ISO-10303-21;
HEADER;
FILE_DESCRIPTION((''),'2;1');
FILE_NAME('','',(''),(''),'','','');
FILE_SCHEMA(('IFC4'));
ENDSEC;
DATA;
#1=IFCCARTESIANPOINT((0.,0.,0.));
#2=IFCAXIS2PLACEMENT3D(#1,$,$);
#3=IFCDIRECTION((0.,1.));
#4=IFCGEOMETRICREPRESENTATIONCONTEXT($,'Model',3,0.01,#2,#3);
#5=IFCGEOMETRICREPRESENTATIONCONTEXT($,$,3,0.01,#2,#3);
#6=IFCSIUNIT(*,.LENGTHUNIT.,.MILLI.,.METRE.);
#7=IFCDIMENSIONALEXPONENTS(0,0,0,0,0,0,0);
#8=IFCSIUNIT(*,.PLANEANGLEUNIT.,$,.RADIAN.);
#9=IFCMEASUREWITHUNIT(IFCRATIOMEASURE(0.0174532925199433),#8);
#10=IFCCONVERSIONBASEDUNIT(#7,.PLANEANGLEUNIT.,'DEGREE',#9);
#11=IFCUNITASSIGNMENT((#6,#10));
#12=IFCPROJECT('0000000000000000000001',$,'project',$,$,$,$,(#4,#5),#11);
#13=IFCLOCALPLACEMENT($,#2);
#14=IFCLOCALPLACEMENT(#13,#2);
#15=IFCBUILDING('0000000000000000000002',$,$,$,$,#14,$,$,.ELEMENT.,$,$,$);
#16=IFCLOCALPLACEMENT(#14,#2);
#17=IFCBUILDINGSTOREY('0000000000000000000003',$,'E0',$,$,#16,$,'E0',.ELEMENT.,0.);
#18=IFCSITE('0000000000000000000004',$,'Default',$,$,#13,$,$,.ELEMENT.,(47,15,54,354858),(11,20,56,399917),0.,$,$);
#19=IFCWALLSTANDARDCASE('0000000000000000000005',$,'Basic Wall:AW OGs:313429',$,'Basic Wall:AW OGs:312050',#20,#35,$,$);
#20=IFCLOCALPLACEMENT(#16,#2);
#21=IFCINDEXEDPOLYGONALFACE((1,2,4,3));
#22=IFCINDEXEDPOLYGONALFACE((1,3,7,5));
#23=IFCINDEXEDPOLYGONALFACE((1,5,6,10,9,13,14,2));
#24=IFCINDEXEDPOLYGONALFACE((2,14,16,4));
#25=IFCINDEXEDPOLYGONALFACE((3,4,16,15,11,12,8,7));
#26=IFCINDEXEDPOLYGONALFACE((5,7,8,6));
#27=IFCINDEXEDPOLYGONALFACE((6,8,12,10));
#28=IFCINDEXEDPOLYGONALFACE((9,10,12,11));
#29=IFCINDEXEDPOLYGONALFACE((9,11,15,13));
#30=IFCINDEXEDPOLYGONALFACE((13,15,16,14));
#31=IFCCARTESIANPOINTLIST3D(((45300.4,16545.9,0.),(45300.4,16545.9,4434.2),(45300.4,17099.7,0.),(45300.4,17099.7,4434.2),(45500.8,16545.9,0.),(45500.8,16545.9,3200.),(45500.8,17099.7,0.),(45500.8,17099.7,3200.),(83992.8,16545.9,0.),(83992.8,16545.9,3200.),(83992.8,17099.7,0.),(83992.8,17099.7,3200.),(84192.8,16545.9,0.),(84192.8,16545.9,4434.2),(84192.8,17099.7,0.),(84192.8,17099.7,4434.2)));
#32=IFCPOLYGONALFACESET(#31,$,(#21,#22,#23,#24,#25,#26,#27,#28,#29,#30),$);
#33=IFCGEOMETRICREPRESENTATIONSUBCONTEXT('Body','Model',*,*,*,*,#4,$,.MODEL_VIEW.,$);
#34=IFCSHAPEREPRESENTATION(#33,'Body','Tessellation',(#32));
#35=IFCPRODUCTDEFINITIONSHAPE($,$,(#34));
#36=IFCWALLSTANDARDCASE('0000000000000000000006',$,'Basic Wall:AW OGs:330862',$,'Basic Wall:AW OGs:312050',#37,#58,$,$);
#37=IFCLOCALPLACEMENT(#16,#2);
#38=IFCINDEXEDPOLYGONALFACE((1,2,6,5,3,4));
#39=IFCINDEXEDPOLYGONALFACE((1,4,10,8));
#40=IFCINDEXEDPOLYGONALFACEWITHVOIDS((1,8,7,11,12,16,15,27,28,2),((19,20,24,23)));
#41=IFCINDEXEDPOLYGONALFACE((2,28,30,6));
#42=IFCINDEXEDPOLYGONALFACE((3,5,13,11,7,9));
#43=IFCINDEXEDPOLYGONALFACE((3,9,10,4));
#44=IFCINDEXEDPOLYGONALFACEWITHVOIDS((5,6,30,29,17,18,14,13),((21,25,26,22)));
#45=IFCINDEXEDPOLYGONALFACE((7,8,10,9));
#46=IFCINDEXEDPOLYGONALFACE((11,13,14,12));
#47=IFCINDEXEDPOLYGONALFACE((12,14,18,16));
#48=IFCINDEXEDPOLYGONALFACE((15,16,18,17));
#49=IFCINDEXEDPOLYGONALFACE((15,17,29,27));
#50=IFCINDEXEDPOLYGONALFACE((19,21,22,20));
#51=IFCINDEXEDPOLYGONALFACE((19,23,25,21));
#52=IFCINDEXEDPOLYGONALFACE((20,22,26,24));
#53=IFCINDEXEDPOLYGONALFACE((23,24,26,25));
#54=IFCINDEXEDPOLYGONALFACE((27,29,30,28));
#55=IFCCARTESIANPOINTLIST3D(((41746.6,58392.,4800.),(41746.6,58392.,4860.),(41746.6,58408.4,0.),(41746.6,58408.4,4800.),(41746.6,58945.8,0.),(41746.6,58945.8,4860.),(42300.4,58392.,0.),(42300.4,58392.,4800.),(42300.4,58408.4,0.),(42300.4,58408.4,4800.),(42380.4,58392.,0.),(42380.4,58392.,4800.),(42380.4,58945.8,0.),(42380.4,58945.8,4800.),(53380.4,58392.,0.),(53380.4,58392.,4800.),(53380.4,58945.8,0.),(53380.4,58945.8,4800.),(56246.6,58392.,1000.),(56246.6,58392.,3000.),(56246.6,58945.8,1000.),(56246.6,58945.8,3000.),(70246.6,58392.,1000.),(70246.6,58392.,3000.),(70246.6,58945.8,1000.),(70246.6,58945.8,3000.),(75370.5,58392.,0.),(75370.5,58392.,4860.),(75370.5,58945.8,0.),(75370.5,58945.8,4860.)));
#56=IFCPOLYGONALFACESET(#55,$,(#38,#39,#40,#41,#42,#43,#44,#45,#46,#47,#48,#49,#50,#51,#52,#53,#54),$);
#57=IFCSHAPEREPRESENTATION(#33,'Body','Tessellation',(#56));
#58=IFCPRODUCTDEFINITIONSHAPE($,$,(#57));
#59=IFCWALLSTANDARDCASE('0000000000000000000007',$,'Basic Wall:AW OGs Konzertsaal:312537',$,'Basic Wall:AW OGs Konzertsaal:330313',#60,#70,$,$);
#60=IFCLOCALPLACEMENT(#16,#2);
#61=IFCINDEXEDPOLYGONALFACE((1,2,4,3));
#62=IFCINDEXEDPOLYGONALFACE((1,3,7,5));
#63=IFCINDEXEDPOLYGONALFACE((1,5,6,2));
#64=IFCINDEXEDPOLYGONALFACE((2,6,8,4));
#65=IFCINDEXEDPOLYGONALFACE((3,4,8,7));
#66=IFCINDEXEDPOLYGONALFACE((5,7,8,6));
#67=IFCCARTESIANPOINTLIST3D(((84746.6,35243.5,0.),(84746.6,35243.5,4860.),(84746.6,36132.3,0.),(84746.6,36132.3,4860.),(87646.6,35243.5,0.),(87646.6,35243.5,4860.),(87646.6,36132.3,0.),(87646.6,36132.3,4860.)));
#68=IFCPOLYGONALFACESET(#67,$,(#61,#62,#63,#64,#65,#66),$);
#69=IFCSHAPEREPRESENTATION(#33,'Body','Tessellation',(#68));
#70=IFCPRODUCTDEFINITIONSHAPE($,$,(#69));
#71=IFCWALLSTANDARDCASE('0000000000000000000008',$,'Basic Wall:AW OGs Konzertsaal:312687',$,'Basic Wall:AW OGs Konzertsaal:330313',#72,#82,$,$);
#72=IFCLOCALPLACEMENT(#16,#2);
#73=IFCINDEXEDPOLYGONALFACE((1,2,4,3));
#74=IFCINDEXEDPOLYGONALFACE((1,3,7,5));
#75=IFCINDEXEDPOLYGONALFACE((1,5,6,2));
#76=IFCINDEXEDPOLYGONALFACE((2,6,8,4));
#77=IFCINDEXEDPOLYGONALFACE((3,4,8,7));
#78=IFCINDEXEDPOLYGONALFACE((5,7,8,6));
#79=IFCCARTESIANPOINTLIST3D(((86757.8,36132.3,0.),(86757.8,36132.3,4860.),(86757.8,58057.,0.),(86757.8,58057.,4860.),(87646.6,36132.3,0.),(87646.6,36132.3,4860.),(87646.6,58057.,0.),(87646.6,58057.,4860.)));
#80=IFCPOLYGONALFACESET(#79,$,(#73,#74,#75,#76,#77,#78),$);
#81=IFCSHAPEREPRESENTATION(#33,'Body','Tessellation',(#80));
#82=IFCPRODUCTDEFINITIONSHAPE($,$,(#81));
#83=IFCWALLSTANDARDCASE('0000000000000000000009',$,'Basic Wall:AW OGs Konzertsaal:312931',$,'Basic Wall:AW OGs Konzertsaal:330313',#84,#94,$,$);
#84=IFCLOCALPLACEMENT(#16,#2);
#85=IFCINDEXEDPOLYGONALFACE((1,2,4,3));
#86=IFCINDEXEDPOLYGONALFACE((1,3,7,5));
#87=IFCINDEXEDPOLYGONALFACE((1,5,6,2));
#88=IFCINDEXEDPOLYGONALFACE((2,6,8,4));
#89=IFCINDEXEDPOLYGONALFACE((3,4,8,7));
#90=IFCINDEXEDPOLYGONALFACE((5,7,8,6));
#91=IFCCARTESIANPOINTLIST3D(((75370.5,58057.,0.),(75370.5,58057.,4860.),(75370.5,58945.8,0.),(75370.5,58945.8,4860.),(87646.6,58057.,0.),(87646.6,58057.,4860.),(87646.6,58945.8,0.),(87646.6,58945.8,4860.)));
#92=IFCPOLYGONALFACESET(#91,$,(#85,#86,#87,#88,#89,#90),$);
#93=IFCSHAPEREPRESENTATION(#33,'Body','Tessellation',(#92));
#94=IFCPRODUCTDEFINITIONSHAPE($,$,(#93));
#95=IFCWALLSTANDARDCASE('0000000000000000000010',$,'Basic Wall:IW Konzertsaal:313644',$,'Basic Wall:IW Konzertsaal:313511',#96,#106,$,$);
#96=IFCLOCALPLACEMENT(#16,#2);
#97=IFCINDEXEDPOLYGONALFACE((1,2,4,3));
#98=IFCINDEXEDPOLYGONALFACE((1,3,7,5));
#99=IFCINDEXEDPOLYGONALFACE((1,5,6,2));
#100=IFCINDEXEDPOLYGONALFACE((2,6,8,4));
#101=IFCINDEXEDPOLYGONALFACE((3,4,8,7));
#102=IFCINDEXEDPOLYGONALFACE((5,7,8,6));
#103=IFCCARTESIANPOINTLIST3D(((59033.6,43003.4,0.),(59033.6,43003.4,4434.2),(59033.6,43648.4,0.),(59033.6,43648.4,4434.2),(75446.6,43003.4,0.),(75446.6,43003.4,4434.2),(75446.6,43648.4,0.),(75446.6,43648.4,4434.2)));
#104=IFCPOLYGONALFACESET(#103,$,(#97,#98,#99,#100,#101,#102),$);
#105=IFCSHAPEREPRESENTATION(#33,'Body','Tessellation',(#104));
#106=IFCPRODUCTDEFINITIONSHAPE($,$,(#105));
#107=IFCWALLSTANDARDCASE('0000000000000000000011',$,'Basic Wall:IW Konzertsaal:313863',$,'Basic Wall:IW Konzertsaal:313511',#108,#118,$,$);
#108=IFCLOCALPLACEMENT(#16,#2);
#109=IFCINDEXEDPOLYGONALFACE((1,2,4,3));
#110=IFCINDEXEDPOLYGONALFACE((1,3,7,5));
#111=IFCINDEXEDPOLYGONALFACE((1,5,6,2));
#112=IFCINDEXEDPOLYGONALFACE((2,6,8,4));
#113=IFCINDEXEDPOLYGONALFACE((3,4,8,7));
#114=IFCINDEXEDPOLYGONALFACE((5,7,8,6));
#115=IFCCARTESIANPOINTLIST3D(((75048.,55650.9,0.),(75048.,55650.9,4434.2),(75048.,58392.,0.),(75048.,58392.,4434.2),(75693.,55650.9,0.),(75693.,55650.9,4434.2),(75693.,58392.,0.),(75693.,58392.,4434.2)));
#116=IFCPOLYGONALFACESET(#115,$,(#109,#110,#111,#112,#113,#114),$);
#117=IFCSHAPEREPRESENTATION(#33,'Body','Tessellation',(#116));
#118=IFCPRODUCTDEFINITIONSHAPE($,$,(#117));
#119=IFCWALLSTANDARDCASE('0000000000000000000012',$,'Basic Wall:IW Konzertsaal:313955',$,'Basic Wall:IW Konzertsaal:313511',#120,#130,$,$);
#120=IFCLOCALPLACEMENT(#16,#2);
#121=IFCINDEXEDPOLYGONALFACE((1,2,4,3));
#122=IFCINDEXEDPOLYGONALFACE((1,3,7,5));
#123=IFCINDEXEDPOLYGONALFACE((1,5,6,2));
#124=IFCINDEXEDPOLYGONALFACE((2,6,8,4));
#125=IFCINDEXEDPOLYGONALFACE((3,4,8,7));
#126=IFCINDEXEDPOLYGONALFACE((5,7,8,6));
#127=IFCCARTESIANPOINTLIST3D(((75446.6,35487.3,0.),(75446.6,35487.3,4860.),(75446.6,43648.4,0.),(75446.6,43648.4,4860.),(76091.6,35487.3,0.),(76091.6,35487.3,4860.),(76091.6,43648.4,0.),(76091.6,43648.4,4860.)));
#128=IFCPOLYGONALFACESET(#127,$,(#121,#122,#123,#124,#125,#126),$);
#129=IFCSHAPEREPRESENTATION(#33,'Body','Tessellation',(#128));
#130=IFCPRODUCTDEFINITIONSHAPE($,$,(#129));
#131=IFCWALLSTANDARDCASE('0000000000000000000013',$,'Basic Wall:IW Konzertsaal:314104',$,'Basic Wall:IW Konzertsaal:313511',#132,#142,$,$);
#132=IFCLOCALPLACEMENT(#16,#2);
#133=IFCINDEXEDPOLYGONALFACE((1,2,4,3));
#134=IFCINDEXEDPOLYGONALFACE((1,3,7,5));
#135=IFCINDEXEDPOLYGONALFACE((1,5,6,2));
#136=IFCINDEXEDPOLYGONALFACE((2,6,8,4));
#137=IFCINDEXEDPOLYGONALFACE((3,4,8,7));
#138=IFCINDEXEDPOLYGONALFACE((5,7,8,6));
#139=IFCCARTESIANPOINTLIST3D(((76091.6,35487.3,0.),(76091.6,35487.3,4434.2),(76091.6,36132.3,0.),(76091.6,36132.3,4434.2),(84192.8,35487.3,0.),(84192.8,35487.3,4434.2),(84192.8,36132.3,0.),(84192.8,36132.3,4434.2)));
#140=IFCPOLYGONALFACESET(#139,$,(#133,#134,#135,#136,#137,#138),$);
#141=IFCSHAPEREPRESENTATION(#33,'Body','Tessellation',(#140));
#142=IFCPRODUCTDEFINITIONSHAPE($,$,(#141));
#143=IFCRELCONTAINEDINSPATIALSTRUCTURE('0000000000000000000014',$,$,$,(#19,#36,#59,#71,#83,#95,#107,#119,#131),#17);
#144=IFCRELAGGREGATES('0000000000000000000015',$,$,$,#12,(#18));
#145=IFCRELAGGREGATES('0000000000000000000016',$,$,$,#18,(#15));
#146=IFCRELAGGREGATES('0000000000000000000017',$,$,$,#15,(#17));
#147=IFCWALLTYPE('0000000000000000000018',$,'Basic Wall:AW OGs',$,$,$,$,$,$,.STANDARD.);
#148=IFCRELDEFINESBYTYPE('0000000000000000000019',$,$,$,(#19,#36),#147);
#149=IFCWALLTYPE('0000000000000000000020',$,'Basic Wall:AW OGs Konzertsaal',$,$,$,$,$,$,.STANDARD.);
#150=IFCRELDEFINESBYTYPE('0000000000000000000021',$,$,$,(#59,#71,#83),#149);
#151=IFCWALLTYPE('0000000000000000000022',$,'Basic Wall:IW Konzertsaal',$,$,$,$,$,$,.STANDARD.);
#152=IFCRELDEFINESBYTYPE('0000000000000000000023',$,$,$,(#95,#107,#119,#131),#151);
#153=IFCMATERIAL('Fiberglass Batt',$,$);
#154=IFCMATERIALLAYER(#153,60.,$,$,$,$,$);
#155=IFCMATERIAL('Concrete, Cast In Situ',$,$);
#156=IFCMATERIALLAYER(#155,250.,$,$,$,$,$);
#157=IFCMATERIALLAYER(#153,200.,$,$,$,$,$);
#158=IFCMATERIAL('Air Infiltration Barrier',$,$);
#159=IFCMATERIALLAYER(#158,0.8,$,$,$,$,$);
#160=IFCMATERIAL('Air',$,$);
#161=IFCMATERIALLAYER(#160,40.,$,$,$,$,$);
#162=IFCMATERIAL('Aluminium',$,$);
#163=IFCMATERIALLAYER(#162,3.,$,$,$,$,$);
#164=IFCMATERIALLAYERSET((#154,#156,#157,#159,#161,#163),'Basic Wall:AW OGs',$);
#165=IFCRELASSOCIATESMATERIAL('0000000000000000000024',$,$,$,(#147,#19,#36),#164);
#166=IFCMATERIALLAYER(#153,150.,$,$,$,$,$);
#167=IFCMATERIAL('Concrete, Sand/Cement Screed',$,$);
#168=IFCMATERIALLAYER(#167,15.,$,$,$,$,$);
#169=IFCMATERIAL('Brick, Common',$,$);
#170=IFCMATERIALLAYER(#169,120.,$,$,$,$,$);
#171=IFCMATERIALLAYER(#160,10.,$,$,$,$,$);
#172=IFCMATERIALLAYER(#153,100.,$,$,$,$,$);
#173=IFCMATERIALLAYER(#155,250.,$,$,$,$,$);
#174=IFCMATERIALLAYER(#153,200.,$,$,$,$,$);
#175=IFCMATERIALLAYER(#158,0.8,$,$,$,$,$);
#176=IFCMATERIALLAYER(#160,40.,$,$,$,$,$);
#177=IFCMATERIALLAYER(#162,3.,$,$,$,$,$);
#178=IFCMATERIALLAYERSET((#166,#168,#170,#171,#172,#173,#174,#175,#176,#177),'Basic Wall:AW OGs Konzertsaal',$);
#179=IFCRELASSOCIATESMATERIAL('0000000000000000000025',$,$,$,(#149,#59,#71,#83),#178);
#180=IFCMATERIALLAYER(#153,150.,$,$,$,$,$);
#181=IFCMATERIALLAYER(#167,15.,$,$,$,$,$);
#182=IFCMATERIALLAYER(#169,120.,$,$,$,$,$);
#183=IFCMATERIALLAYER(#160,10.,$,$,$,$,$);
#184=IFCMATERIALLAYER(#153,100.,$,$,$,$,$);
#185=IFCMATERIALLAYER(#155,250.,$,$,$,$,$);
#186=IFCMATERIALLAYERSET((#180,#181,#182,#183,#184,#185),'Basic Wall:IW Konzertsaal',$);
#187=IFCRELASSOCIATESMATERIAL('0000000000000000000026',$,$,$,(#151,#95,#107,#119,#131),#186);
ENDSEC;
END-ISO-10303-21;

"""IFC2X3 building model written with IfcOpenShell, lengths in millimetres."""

from ifc_helpers import new_model, entity, si_unit, converted_unit, direction, frame, frame_2d, origin, place, context, subcontext, project, spatial, polyline, rectangle, extrude, clip, bounded_halfspace, material, layer, layer_set, layer_usage, type_object, element, save


model = new_model("IFC2X3")

# Units and contexts
model_context = context("Model", 3, precision=0.01, world=origin(), true_north=direction((0.0, 1.0)))
context_of_model = context(None, 3, precision=0.01, world=origin(), true_north=direction((0.0, 1.0)))
body_context = subcontext(model_context, "Body", "Model", "MODEL_VIEW")
ifc_project = project(units=[si_unit("LENGTHUNIT", "METRE", prefix="MILLI"), converted_unit("PLANEANGLEUNIT", "DEGREE", entity("IfcRatioMeasure", 0.0174532925199433), si_unit("PLANEANGLEUNIT", "RADIAN"), dimensions=[0, 0, 0, 0, 0, 0, 0])], contexts=[model_context, context_of_model])

# Site, building, storey
site_placement = place(None, origin())
site = spatial("IfcSite", under=ifc_project, at=site_placement, Name="Default", CompositionType="ELEMENT", RefLatitude=(47, 15, 54, 354858), RefLongitude=(11, 20, 56, 399917), RefElevation=0.0)
building_placement = place(site_placement, origin())
building = spatial("IfcBuilding", under=site, at=building_placement, CompositionType="ELEMENT")
storey_placement = place(building_placement, origin())
storey = spatial("IfcBuildingStorey", under=building, at=storey_placement, Name="E0", LongName="E0", CompositionType="ELEMENT", Elevation=0.0)

# Shared definitions
ifc_material_1 = material(Name="Concrete, Sand/Cement Screed")
ifc_material_2 = material(Name="Air Infiltration Barrier")
ifc_material_3 = material(Name="Fiberglass Batt")

# Shared definitions
ifc_material_4 = material(Name="Concrete, Cast In Situ")

# Shared definitions
ifc_layer_1 = layer(ifc_material_3, 60.0)
ifc_layer_2 = layer(ifc_material_4, 250.0)
ifc_layer_3 = layer(ifc_material_3, 200.0)
ifc_layer_4 = layer(ifc_material_2, 0.8)
ifc_material_5 = material(Name="Air")
ifc_layer_5 = layer(ifc_material_5, 40.0)
ifc_material_6 = material(Name="Aluminium")
ifc_layer_6 = layer(ifc_material_6, 3.0)
ifc_layer_set_1 = layer_set([ifc_layer_1, ifc_layer_2, ifc_layer_3, ifc_layer_4, ifc_layer_5, ifc_layer_6], Name="Basic Wall:AW OGs")
wall_type_1 = type_object("IfcWallType", Name="Basic Wall:AW OGs", PredefinedType="STANDARD", material=ifc_layer_set_1)

# Wall, opening
ifc_layer_usage_1 = layer_usage(ifc_layer_set_1, "AXIS2", "NEGATIVE", 276.9)
wall_1_placement = place(storey_placement, frame((45300.4, 16822.8, 0.0)))
wall_1 = element("IfcWallStandardCase", 1, at=wall_1_placement, inside=storey, type_object=wall_type_1, material=ifc_layer_usage_1, Name="Basic Wall:AW OGs:313429", ObjectType="Basic Wall:AW OGs:312050", context=body_context, shape_type="Clipping", body=[
    clip(extrude(rectangle(XDim=38892.4, YDim=553.8, at=frame_2d((19446.2, 0.0), x_axis=(-1.0, 0.0))), origin(), (0.0, 0.0, 1.0), 4434.2), bounded_halfspace(frame((38892.4, 276.9, 4434.2), z_axis=(0.0, 0.0, -1.0), x_axis=(1.0, 0.0, 0.0)), True, frame((38892.4, 276.9, 4434.2)), polyline([(0.0, 0.0), (-38892.4, 0.0), (-38892.4, -553.8), (-13770.9, -553.8), (-13125.9, -553.8), (0.0, -553.8), (0.0, 0.0)]))),
])
opening_1_placement = place(wall_1_placement, frame((38692.4, 276.9, 0.0)))
element("IfcOpeningElement", 2, at=opening_1_placement, cuts=wall_1, ObjectType="Opening", context=body_context, shape_type="SweptSolid", body=[
    extrude(rectangle(XDim=3200.0, YDim=38492.0, at=frame_2d((1600.0, 19246.0), x_axis=(-1.0, 0.0))), frame((0.0, 0.0, 0.0), z_axis=(0.0, -1.0, 0.0), x_axis=(0.0, 0.0, 1.0)), (0.0, 0.0, 1.0), 553.8),
])

# Wall, openings
ifc_layer_usage_2 = layer_usage(ifc_layer_set_1, "AXIS2", "NEGATIVE", 276.9)
wall_2_placement = place(storey_placement, frame((75693.0, 58668.9, 0.0), z_axis=(0.0, 0.0, 1.0), x_axis=(-1.0, 0.0, 0.0)))
wall_2 = element("IfcWallStandardCase", 3, at=wall_2_placement, inside=storey, type_object=wall_type_1, material=ifc_layer_usage_2, Name="Basic Wall:AW OGs:330862", ObjectType="Basic Wall:AW OGs:312050", context=body_context, shape_type="SweptSolid", body=[
    extrude(rectangle(XDim=33623.9, YDim=553.8, at=frame_2d((17134.4, 0.0), x_axis=(1.0, 0.0))), origin(), (0.0, 0.0, 1.0), 4860.0),
])
opening_2_placement = place(wall_2_placement, origin())
element("IfcOpeningElement", 4, at=opening_2_placement, cuts=wall_2, ObjectType="Opening", context=body_context, shape_type="SweptSolid", body=[
    extrude(rectangle(XDim=4800.0, YDim=553.8, at=frame_2d((0.0, 0.0), x_axis=(0.0, 1.0))), frame((33669.5, 260.5, 2400.0), z_axis=(0.0, 1.0, 0.0), x_axis=(1.0, 0.0, 0.0)), (0.0, 0.0, 1.0), 15000.0),
])
opening_3_placement = place(wall_2_placement, frame((33312.6, 276.9, 0.0)))
element("IfcOpeningElement", 5, at=opening_3_placement, cuts=wall_2, ObjectType="Opening", context=body_context, shape_type="SweptSolid", body=[
    extrude(rectangle(XDim=4800.0, YDim=11000.0, at=frame_2d((2400.0, 5500.0), x_axis=(-1.0, 0.0))), frame((0.0, 0.0, 0.0), z_axis=(0.0, -1.0, 0.0), x_axis=(0.0, 0.0, 1.0)), (0.0, 0.0, 1.0), 553.8),
])
opening_4_placement = place(wall_2_placement, frame((19446.4, 276.9, 1000.0)))
element("IfcOpeningElement", 6, at=opening_4_placement, cuts=wall_2, ObjectType="Opening", context=body_context, shape_type="SweptSolid", body=[
    extrude(rectangle(XDim=2000.0, YDim=14000.0, at=frame_2d((1000.0, 7000.0), x_axis=(-1.0, 0.0))), frame((0.0, 0.0, 0.0), z_axis=(0.0, -1.0, 0.0), x_axis=(0.0, 0.0, 1.0)), (0.0, 0.0, 1.0), 553.8),
])

# Walls
ifc_layer_7 = layer(ifc_material_3, 150.0)
ifc_layer_8 = layer(ifc_material_1, 15.0)
ifc_material_7 = material(Name="Brick, Common")
ifc_layer_9 = layer(ifc_material_7, 120.0)
ifc_layer_10 = layer(ifc_material_5, 10.0)
ifc_layer_11 = layer(ifc_material_3, 100.0)
ifc_layer_12 = layer(ifc_material_4, 250.0)
ifc_layer_13 = layer(ifc_material_3, 200.0)
ifc_layer_14 = layer(ifc_material_2, 0.8)
ifc_layer_15 = layer(ifc_material_5, 40.0)
ifc_layer_16 = layer(ifc_material_6, 3.0)
ifc_layer_set_2 = layer_set([ifc_layer_7, ifc_layer_8, ifc_layer_9, ifc_layer_10, ifc_layer_11, ifc_layer_12, ifc_layer_13, ifc_layer_14, ifc_layer_15, ifc_layer_16], Name="Basic Wall:AW OGs Konzertsaal")
ifc_layer_usage_3 = layer_usage(ifc_layer_set_2, "AXIS2", "NEGATIVE", 444.4)
wall_type_2 = type_object("IfcWallType", Name="Basic Wall:AW OGs Konzertsaal", PredefinedType="STANDARD", material=ifc_layer_set_2)
wall_3_placement = place(storey_placement, frame((84746.6, 35687.9, 0.0)))
element("IfcWallStandardCase", 7, at=wall_3_placement, inside=storey, type_object=wall_type_2, material=ifc_layer_usage_3, Name="Basic Wall:AW OGs Konzertsaal:312537", ObjectType="Basic Wall:AW OGs Konzertsaal:330313", context=body_context, shape_type="SweptSolid", body=[
    extrude(rectangle(XDim=2900.0, YDim=888.8, at=frame_2d((1450.0, 0.0), x_axis=(-1.0, 0.0))), origin(), (0.0, 0.0, 1.0), 4860.0),
])
ifc_layer_usage_4 = layer_usage(ifc_layer_set_2, "AXIS2", "NEGATIVE", 444.4)
wall_4_placement = place(storey_placement, frame((87202.2, 36132.3, 0.0), z_axis=(0.0, 0.0, 1.0), x_axis=(0.0, 1.0, 0.0)))
element("IfcWallStandardCase", 8, at=wall_4_placement, inside=storey, type_object=wall_type_2, material=ifc_layer_usage_4, Name="Basic Wall:AW OGs Konzertsaal:312687", ObjectType="Basic Wall:AW OGs Konzertsaal:330313", context=body_context, shape_type="SweptSolid", body=[
    extrude(rectangle(XDim=21924.7, YDim=888.8, at=frame_2d((10962.4, 0.0), x_axis=(-1.0, 0.0))), origin(), (0.0, 0.0, 1.0), 4860.0),
])
ifc_layer_usage_5 = layer_usage(ifc_layer_set_2, "AXIS2", "NEGATIVE", 444.4)
wall_5_placement = place(storey_placement, frame((87646.6, 58501.4, 0.0), z_axis=(0.0, 0.0, 1.0), x_axis=(-1.0, 0.0, 0.0)))
element("IfcWallStandardCase", 9, at=wall_5_placement, inside=storey, type_object=wall_type_2, material=ifc_layer_usage_5, Name="Basic Wall:AW OGs Konzertsaal:312931", ObjectType="Basic Wall:AW OGs Konzertsaal:330313", context=body_context, shape_type="SweptSolid", body=[
    extrude(rectangle(XDim=12276.1, YDim=888.8, at=frame_2d((6138.1, 0.0), x_axis=(-1.0, 0.0))), origin(), (0.0, 0.0, 1.0), 4860.0),
])
ifc_layer_17 = layer(ifc_material_3, 150.0)
ifc_layer_18 = layer(ifc_material_1, 15.0)
ifc_layer_19 = layer(ifc_material_7, 120.0)
ifc_layer_20 = layer(ifc_material_5, 10.0)
ifc_layer_21 = layer(ifc_material_3, 100.0)
ifc_layer_22 = layer(ifc_material_4, 250.0)
ifc_layer_set_3 = layer_set([ifc_layer_17, ifc_layer_18, ifc_layer_19, ifc_layer_20, ifc_layer_21, ifc_layer_22], Name="Basic Wall:IW Konzertsaal")
ifc_layer_usage_6 = layer_usage(ifc_layer_set_3, "AXIS2", "POSITIVE", -322.5)
wall_type_3 = type_object("IfcWallType", Name="Basic Wall:IW Konzertsaal", PredefinedType="STANDARD", material=ifc_layer_set_3)
wall_6_placement = place(storey_placement, frame((75446.6, 43325.9, 0.0), z_axis=(0.0, 0.0, 1.0), x_axis=(-1.0, 0.0, 0.0)))
element("IfcWallStandardCase", 10, at=wall_6_placement, inside=storey, type_object=wall_type_3, material=ifc_layer_usage_6, Name="Basic Wall:IW Konzertsaal:313644", ObjectType="Basic Wall:IW Konzertsaal:313511", context=body_context, shape_type="Clipping", body=[
    clip(extrude(rectangle(XDim=16413.0, YDim=645.0, at=frame_2d((8206.5, 0.0), x_axis=(-1.0, 0.0))), origin(), (0.0, 0.0, 1.0), 4434.2), bounded_halfspace(frame((0.0, -322.5, 4434.2), z_axis=(0.0, 0.0, -1.0), x_axis=(-1.0, 0.0, 0.0)), True, frame((0.0, -322.5, 4434.2)), polyline([(0.0, 0.0), (6295.0, 0.0), (6295.0, 645.0), (0.0, 645.0), (0.0, 0.0)]))),
])
ifc_layer_usage_7 = layer_usage(ifc_layer_set_3, "AXIS2", "POSITIVE", -322.5)
wall_7_placement = place(storey_placement, frame((75370.5, 55650.9, 0.0), z_axis=(0.0, 0.0, 1.0), x_axis=(0.0, 1.0, 0.0)))
element("IfcWallStandardCase", 11, at=wall_7_placement, inside=storey, type_object=wall_type_3, material=ifc_layer_usage_7, Name="Basic Wall:IW Konzertsaal:313863", ObjectType="Basic Wall:IW Konzertsaal:313511", context=body_context, shape_type="Clipping", body=[
    clip(extrude(rectangle(XDim=2741.2, YDim=645.0, at=frame_2d((1370.6, 0.0), x_axis=(-1.0, 0.0))), origin(), (0.0, 0.0, 1.0), 4434.2), bounded_halfspace(frame((0.0, -322.5, 4434.2), z_axis=(0.0, 0.0, -1.0), x_axis=(0.0, -1.0, 0.0)), True, frame((0.0, -322.5, 4434.2)), polyline([(0.0, 0.0), (2406.2, 0.0), (2741.2, 0.0), (2741.2, 322.5), (2741.2, 645.0), (0.0, 645.0), (0.0, 0.0)]))),
])
ifc_layer_usage_8 = layer_usage(ifc_layer_set_3, "AXIS2", "NEGATIVE", 322.5)
wall_8_placement = place(storey_placement, frame((75769.1, 43648.4, 0.0), z_axis=(0.0, 0.0, 1.0), x_axis=(0.0, -1.0, 0.0)))
element("IfcWallStandardCase", 12, at=wall_8_placement, inside=storey, type_object=wall_type_3, material=ifc_layer_usage_8, Name="Basic Wall:IW Konzertsaal:313955", ObjectType="Basic Wall:IW Konzertsaal:313511", context=body_context, shape_type="SweptSolid", body=[
    extrude(rectangle(XDim=8161.1, YDim=645.0, at=frame_2d((4080.5, 0.0), x_axis=(-1.0, 0.0))), origin(), (0.0, 0.0, 1.0), 4860.0),
])
ifc_layer_usage_9 = layer_usage(ifc_layer_set_3, "AXIS2", "NEGATIVE", 322.5)
wall_9_placement = place(storey_placement, frame((76091.6, 35809.8, 0.0)))
element("IfcWallStandardCase", 13, at=wall_9_placement, inside=storey, type_object=wall_type_3, material=ifc_layer_usage_9, Name="Basic Wall:IW Konzertsaal:314104", ObjectType="Basic Wall:IW Konzertsaal:313511", context=body_context, shape_type="Clipping", body=[
    clip(extrude(rectangle(XDim=8101.2, YDim=645.0, at=frame_2d((4050.6, 0.0), x_axis=(-1.0, 0.0))), origin(), (0.0, 0.0, 1.0), 4434.2), bounded_halfspace(frame((0.0, -322.5, 4434.2), z_axis=(0.0, 0.0, -1.0), x_axis=(1.0, 0.0, 0.0)), True, frame((0.0, -322.5, 4434.2)), polyline([(0.0, 0.0), (8101.2, 0.0), (8101.2, 645.0), (0.0, 645.0), (0.0, 0.0)]))),
])

save(model, "model.ifc")
